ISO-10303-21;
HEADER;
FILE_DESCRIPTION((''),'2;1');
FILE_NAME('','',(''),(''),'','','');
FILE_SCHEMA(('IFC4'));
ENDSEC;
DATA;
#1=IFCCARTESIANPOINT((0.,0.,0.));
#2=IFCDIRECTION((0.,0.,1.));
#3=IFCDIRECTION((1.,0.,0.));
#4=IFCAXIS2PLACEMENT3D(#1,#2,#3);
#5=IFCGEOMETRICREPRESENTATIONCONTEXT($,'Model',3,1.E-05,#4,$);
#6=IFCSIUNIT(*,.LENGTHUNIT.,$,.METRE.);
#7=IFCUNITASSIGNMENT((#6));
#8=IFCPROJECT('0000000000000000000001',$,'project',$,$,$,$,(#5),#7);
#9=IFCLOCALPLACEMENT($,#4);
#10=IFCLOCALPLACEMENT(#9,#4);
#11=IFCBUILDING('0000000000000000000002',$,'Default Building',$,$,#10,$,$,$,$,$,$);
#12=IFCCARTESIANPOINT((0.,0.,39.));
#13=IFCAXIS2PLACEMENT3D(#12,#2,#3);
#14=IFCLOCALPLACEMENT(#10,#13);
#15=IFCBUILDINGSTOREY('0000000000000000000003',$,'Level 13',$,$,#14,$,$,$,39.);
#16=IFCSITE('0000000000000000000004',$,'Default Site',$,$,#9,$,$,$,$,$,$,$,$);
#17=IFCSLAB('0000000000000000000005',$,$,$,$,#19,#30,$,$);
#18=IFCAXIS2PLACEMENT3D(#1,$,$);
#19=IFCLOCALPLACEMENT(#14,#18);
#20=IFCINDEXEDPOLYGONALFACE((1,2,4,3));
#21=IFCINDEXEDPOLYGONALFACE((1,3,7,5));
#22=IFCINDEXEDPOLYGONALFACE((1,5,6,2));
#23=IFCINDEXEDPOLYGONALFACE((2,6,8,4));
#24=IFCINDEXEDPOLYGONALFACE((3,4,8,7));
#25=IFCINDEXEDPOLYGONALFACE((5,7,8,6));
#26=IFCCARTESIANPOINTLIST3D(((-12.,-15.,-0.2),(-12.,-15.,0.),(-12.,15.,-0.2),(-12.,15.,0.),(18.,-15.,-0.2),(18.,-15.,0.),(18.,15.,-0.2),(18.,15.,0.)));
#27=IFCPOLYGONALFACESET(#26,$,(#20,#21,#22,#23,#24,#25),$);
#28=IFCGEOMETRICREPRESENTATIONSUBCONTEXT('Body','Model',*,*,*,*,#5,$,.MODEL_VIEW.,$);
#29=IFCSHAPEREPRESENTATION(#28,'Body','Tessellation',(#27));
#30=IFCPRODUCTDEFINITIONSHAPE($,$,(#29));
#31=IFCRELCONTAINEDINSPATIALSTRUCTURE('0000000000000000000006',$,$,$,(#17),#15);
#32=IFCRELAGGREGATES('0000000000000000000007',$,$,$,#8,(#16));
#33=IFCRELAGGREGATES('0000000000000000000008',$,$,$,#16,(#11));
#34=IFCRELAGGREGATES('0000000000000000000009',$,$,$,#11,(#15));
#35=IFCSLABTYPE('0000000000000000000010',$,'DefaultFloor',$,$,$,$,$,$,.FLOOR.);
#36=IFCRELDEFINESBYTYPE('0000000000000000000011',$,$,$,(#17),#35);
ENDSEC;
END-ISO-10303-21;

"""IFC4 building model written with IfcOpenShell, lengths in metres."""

from ifc_helpers import new_model, si_unit, frame, origin_with_axes, place, context, subcontext, project, spatial, polyline, outline, extrude, type_object, element, save


model = new_model("IFC4")

# Units and contexts
model_context = context("Model", 3, precision=1e-05, world=origin_with_axes())
body_context = subcontext(model_context, "Body", "Model", "MODEL_VIEW")
ifc_project = project(units=[si_unit("LENGTHUNIT", "METRE")], contexts=[model_context])

# Site, building, storey
site_placement = place(None, origin_with_axes())
site = spatial("IfcSite", under=ifc_project, at=site_placement, Name="Default Site")
building_placement = place(site_placement, origin_with_axes())
building = spatial("IfcBuilding", under=site, at=building_placement, Name="Default Building")
storey_placement = place(building_placement, frame((0.0, 0.0, 39.0), z_axis=(0.0, 0.0, 1.0), x_axis=(1.0, 0.0, 0.0)))
storey = spatial("IfcBuildingStorey", under=building, at=storey_placement, Name="Level 13", Elevation=39.0)

# Slab
slab_type = type_object("IfcSlabType", Name="DefaultFloor", PredefinedType="FLOOR")
slab_placement = place(storey_placement, frame((0.0, 0.0, -39.0), z_axis=(0.0, 0.0, 1.0), x_axis=(1.0, 0.0, 0.0)))
element("IfcSlab", 1, at=slab_placement, inside=storey, type_object=slab_type, context=body_context, shape_type="SweptSolid", body=[
    extrude(outline(polyline([(-12.0, 15.0), (18.0, 15.0), (18.0, -15.0), (-12.0, -15.0), (-12.0, 15.0)])), frame((0.0, 0.0, 39.0), z_axis=(0.0, 0.0, 1.0), x_axis=(1.0, 0.0, 0.0)), (0.0, 0.0, -1.0), 0.2),
])

save(model, "model.ifc")
